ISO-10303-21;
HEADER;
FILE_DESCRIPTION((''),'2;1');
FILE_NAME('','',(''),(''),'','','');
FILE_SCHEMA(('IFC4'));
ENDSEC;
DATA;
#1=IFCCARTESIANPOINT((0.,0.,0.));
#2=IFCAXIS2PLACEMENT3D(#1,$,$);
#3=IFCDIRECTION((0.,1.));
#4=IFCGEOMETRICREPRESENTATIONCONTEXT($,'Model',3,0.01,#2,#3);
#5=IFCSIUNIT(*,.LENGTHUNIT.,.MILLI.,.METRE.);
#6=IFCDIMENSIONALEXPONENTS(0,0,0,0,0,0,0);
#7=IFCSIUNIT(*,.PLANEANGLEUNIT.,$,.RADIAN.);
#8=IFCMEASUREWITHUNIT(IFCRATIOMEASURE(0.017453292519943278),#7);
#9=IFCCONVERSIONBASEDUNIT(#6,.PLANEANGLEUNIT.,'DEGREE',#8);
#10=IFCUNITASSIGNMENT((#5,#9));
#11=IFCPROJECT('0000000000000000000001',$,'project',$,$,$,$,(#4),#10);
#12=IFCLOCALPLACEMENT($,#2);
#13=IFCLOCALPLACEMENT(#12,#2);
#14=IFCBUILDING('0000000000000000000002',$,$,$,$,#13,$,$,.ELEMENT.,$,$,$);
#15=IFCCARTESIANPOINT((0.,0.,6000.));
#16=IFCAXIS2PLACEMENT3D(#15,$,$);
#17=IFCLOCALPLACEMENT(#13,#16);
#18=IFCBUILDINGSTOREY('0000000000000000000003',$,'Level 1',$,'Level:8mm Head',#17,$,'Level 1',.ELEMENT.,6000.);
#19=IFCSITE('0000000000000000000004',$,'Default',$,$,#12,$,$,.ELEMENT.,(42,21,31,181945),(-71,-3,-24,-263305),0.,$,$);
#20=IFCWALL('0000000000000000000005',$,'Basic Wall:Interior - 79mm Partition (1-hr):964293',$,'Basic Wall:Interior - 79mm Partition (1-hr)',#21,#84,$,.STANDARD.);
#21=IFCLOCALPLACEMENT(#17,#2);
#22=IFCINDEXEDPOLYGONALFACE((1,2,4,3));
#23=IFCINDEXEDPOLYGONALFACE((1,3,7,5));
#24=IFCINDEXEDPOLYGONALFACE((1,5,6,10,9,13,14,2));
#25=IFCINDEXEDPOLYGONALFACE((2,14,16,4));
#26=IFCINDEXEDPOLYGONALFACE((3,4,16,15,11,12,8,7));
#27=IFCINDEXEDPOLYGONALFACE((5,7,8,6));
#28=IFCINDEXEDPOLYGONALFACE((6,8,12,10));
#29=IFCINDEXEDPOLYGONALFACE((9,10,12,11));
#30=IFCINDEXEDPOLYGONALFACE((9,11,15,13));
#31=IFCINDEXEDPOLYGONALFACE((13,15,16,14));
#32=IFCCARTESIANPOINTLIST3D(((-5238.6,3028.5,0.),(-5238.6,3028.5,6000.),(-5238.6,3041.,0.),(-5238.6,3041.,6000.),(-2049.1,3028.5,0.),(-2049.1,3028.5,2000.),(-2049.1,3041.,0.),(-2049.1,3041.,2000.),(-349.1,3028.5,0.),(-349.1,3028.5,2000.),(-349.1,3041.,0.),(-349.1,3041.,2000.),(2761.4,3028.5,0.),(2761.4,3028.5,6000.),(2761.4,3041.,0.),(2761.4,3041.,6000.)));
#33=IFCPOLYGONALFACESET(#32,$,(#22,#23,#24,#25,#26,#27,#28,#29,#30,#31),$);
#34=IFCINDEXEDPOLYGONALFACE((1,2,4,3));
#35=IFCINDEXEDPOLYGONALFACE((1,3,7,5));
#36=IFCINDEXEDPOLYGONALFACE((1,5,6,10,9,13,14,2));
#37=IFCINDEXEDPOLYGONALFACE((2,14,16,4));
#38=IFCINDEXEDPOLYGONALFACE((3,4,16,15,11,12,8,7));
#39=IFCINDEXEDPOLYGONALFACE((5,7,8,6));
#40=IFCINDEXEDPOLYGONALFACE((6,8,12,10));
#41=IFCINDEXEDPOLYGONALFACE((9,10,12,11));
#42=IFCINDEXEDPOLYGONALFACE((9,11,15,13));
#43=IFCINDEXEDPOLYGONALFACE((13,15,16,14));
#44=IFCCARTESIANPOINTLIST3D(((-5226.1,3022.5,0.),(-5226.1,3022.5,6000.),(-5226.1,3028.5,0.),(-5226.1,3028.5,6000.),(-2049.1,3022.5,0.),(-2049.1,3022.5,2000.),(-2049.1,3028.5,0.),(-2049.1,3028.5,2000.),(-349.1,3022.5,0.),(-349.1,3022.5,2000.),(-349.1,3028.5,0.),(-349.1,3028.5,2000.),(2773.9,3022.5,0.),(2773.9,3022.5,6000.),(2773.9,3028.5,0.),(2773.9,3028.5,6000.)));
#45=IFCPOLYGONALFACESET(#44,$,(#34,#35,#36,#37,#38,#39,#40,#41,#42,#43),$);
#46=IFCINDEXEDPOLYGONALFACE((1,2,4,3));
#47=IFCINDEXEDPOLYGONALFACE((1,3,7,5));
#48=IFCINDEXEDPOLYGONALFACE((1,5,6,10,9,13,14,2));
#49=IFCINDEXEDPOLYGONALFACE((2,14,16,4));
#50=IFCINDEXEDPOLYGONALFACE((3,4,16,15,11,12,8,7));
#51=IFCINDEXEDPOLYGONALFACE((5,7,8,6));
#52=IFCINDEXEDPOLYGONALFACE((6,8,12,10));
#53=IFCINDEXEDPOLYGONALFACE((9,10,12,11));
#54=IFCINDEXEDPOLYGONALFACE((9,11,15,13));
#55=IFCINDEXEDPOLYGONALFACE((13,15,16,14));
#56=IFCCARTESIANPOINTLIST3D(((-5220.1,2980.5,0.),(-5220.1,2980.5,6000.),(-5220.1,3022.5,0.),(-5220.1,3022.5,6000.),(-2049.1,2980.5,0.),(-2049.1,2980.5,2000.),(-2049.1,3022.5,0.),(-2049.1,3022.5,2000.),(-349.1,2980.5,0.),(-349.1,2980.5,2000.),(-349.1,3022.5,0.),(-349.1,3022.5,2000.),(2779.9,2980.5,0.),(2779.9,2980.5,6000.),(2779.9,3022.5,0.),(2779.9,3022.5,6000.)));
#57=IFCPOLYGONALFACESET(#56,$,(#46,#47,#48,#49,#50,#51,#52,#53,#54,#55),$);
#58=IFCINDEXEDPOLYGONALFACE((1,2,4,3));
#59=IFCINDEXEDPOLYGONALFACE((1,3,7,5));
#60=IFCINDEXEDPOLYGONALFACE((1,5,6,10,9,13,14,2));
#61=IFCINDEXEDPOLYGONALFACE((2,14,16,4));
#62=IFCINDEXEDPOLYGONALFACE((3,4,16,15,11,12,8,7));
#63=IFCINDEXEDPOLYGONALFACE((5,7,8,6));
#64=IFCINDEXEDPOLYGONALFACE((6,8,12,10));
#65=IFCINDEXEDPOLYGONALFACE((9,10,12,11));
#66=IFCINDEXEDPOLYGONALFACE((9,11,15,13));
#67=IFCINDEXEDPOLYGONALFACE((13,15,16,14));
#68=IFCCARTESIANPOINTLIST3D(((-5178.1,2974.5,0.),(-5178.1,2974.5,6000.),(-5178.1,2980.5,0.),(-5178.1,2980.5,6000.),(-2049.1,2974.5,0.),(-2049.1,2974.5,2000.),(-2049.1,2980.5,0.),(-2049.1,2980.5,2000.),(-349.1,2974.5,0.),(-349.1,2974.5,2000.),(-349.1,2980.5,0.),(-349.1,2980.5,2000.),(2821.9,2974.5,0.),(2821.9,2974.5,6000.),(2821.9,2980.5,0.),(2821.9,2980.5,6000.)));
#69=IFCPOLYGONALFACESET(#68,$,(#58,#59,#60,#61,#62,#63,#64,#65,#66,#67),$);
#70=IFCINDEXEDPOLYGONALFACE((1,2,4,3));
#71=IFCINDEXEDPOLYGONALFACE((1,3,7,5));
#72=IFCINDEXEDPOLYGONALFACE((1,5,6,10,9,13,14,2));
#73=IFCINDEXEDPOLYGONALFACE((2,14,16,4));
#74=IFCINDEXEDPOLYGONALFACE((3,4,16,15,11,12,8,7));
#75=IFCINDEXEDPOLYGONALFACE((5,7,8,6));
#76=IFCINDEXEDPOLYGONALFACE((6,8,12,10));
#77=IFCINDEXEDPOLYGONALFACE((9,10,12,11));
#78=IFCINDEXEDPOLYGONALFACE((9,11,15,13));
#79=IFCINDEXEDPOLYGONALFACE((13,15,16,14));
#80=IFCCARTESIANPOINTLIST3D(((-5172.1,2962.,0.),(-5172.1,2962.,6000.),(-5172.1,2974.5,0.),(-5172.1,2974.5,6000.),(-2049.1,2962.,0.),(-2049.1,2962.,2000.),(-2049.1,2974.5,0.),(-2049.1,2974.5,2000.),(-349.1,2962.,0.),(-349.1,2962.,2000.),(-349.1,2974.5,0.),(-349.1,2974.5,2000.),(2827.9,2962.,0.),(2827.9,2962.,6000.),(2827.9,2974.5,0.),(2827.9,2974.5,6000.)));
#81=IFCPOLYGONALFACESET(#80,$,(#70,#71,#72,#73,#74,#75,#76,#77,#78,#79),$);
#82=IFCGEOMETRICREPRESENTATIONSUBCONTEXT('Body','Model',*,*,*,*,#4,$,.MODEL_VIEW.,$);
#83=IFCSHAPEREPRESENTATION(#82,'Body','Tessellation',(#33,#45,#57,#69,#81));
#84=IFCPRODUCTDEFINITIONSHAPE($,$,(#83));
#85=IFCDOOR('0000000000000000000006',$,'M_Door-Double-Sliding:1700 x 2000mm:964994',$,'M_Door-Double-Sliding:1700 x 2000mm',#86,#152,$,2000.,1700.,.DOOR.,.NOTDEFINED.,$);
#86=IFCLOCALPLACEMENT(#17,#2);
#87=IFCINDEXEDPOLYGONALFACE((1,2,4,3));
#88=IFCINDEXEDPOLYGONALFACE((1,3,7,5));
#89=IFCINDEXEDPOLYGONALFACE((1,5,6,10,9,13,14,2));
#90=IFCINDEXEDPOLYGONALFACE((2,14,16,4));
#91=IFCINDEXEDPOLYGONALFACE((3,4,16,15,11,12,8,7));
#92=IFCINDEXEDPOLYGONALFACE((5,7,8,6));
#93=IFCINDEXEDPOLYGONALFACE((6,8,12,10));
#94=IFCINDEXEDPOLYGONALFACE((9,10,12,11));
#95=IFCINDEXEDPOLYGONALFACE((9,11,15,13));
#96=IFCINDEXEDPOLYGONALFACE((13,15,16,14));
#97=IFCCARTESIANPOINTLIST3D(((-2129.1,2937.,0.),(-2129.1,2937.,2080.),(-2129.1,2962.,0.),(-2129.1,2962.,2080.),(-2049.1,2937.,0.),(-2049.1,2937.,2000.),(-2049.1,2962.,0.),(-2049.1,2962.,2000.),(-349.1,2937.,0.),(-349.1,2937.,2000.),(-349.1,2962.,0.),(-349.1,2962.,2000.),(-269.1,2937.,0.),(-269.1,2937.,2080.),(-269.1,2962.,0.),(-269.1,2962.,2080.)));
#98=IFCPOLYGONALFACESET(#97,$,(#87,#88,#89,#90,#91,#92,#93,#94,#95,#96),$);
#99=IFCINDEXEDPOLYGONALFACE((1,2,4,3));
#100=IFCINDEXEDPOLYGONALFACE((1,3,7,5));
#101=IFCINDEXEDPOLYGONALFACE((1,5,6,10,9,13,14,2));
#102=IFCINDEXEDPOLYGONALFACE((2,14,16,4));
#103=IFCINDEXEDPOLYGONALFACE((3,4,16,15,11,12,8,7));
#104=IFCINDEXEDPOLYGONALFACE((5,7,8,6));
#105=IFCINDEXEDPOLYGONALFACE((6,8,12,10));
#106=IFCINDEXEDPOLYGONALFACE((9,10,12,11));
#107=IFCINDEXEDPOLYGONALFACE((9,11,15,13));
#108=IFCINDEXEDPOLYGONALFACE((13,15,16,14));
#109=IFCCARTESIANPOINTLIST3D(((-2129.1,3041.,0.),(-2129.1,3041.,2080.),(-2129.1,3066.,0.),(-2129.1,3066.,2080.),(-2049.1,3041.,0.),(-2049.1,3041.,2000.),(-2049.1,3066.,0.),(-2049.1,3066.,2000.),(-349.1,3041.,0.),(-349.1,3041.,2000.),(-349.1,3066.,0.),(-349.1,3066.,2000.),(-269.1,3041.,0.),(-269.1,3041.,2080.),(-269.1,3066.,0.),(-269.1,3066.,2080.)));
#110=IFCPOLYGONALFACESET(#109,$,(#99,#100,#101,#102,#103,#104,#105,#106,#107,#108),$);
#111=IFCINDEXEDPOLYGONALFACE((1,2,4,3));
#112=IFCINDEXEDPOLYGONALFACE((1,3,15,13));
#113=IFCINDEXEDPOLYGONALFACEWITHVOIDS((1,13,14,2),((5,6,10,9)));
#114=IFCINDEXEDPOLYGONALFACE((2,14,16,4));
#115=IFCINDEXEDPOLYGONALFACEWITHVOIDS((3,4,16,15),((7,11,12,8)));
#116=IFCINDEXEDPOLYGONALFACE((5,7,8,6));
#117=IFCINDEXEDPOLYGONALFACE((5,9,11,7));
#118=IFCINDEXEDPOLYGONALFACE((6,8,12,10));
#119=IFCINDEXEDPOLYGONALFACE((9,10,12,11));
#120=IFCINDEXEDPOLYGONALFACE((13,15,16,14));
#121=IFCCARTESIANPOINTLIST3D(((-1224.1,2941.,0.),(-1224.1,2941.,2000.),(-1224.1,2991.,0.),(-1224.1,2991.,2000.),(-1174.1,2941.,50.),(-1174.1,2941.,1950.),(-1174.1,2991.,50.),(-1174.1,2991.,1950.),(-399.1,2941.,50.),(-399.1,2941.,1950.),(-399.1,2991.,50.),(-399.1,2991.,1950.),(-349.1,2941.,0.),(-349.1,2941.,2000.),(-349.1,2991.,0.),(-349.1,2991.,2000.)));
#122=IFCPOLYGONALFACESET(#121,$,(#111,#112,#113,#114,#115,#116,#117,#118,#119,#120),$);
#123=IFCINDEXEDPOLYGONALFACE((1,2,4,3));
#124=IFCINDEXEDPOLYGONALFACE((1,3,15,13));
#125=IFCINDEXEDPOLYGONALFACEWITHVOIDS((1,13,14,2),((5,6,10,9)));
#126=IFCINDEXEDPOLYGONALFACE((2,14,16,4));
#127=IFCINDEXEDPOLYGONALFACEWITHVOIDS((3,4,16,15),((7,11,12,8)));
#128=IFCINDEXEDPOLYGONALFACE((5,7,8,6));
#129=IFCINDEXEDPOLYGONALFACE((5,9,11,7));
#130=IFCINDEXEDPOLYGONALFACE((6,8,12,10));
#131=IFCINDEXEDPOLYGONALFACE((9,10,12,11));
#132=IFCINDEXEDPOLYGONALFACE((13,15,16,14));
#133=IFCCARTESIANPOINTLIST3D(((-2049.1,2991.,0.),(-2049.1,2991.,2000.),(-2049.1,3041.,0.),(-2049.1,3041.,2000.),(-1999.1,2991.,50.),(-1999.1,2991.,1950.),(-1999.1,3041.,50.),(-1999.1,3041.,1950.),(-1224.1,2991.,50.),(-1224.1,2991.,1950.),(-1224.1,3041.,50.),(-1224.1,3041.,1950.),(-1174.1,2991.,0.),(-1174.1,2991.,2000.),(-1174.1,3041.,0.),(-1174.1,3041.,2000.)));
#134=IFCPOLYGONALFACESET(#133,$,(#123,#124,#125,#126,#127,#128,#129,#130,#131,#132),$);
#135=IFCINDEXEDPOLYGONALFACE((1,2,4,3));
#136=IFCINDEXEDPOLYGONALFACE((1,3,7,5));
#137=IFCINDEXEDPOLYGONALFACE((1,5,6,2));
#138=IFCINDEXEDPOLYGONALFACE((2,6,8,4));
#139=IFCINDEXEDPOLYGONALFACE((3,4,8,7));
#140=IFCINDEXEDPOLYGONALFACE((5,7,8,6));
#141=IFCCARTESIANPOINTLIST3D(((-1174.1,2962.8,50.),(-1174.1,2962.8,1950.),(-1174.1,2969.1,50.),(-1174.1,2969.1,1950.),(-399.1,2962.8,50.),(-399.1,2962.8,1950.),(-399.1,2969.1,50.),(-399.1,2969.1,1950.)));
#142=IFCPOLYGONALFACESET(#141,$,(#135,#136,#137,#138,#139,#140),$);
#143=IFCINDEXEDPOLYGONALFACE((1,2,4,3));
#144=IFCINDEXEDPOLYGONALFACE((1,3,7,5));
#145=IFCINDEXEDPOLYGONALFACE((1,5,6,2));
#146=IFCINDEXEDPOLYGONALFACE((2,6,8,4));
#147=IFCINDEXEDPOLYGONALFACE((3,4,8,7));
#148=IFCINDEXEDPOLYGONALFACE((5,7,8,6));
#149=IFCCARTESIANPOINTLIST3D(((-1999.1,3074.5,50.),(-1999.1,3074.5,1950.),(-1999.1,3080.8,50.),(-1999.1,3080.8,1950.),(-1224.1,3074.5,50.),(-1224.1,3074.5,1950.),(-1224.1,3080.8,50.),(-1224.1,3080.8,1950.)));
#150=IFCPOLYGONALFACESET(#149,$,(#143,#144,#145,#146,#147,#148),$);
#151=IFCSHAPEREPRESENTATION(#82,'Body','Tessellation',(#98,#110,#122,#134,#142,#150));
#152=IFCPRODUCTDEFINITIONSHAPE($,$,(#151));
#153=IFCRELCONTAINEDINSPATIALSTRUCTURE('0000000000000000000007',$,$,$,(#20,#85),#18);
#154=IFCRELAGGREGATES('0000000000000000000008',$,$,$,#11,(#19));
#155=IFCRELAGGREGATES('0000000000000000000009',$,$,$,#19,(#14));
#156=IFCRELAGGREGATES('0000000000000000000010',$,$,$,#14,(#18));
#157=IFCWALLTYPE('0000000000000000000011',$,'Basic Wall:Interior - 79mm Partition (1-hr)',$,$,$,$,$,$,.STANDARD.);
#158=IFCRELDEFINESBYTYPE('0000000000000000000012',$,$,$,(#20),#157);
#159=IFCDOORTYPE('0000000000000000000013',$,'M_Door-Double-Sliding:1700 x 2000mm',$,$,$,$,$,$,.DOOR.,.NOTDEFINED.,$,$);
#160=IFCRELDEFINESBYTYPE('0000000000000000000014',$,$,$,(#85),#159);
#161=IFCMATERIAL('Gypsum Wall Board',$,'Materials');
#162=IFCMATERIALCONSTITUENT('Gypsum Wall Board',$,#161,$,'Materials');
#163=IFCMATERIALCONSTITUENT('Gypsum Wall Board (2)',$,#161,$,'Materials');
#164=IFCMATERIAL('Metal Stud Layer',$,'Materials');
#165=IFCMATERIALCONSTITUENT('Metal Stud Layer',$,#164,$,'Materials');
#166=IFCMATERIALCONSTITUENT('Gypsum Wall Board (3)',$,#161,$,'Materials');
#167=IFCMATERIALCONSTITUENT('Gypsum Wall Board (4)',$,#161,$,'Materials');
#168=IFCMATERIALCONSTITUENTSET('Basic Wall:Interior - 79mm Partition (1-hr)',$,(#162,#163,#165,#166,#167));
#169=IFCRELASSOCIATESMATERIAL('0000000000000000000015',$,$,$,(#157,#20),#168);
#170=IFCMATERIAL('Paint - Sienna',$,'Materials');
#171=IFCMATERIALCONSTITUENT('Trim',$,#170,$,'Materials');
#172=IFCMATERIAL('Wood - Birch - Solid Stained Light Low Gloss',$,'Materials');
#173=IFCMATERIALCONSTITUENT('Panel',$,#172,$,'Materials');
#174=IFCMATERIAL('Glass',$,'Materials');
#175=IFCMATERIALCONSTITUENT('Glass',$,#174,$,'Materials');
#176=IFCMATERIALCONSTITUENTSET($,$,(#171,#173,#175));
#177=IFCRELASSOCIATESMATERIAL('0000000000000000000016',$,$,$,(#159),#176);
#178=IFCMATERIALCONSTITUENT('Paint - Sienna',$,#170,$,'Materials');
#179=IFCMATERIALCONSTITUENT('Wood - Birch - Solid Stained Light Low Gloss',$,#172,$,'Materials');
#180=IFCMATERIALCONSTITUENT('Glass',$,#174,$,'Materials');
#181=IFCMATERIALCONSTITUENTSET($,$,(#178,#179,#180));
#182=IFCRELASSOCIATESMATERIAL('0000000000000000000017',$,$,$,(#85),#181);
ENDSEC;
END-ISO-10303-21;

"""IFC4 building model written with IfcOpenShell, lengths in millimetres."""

from ifc_helpers import new_model, entity, si_unit, converted_unit, direction, frame, origin, place, context, subcontext, project, spatial, indexed_curve, outline, extrude, source, transform, mapped, material, constituent, constituent_set, type_object, type_shapes, element, fill, save


model = new_model("IFC4")

# Units and contexts
model_context = context("Model", 3, precision=0.01, world=origin(), true_north=direction((0.0, 1.0)))
body_context = subcontext(model_context, "Body", "Model", "MODEL_VIEW")
ifc_project = project(units=[si_unit("LENGTHUNIT", "METRE", prefix="MILLI"), converted_unit("PLANEANGLEUNIT", "DEGREE", entity("IfcRatioMeasure", 0.017453292519943278), si_unit("PLANEANGLEUNIT", "RADIAN"), dimensions=[0, 0, 0, 0, 0, 0, 0])], contexts=[model_context])

# Site, building, storey
site_placement = place(None, origin())
site = spatial("IfcSite", under=ifc_project, at=site_placement, Name="Default", CompositionType="ELEMENT", RefLatitude=(42, 21, 31, 181945), RefLongitude=(-71, -3, -24, -263305), RefElevation=0.0)
building_placement = place(site_placement, origin())
building = spatial("IfcBuilding", under=site, at=building_placement, CompositionType="ELEMENT")
storey_placement = place(building_placement, frame((0.0, 0.0, 6000.0)))
storey = spatial("IfcBuildingStorey", under=building, at=storey_placement, Name="Level 1", ObjectType="Level:8mm Head", LongName="Level 1", CompositionType="ELEMENT", Elevation=6000.0)

# Shared definitions
ifc_material_1 = material(Name="Gypsum Wall Board", Category="Materials")
ifc_constituent_1 = constituent(ifc_material_1, Name="Gypsum Wall Board", Category="Materials")
ifc_constituent_2 = constituent(ifc_material_1, Name="Gypsum Wall Board (2)", Category="Materials")
ifc_material_2 = material(Name="Metal Stud Layer", Category="Materials")
ifc_constituent_3 = constituent(ifc_material_2, Name="Metal Stud Layer", Category="Materials")
ifc_constituent_4 = constituent(ifc_material_1, Name="Gypsum Wall Board (3)", Category="Materials")
ifc_constituent_5 = constituent(ifc_material_1, Name="Gypsum Wall Board (4)", Category="Materials")
ifc_constituent_set_1 = constituent_set(constituents=[ifc_constituent_1, ifc_constituent_2, ifc_constituent_3, ifc_constituent_4, ifc_constituent_5], Name="Basic Wall:Interior - 79mm Partition (1-hr)")
wall_type = type_object("IfcWallType", Name="Basic Wall:Interior - 79mm Partition (1-hr)", PredefinedType="STANDARD", material=ifc_constituent_set_1)

# Wall, opening, door
wall_1_placement = place(storey_placement, frame((2761.4, 3001.5, 0.0), z_axis=(0.0, 0.0, 1.0), x_axis=(-1.0, 0.0, 0.0)))
wall_1 = element("IfcWall", 1, at=wall_1_placement, inside=storey, type_object=wall_type, material=ifc_constituent_set_1, Name="Basic Wall:Interior - 79mm Partition (1-hr):964293", ObjectType="Basic Wall:Interior - 79mm Partition (1-hr)", PredefinedType="STANDARD", context=body_context, shape_type="SweptSolid", body=[
    extrude(outline(indexed_curve([(-2000.0, -869.8), (-2000.0, -3980.3), (4000.0, -3980.3), (4000.0, 4019.8), (-2000.0, 4019.8), (-2000.0, 830.2), (0.0, 830.2), (0.0, -869.8), (-2000.0, -869.8)], self_intersect=False)), frame((3980.3, -27.0, 2000.0), z_axis=(0.0, 1.0, 0.0), x_axis=(0.0, 0.0, 1.0)), (0.0, 0.0, -1.0), 12.5),
    extrude(outline(indexed_curve([(-2000.0, -863.5), (-2000.0, -3986.5), (4000.0, -3986.5), (4000.0, 4013.5), (-2000.0, 4013.5), (-2000.0, 836.5), (0.0, 836.5), (0.0, -863.5), (-2000.0, -863.5)], self_intersect=False)), frame((3974.0, -21.0, 2000.0), z_axis=(0.0, 1.0, 0.0), x_axis=(0.0, 0.0, 1.0)), (0.0, 0.0, -1.0), 6.0),
    extrude(outline(indexed_curve([(-2000.0, -860.5), (-2000.0, -3989.5), (4000.0, -3989.5), (4000.0, 4010.5), (-2000.0, 4010.5), (-2000.0, 839.5), (0.0, 839.5), (0.0, -860.5), (-2000.0, -860.5)], self_intersect=False)), frame((3971.0, 21.0, 2000.0), z_axis=(0.0, 1.0, 0.0), x_axis=(0.0, 0.0, 1.0)), (0.0, 0.0, -1.0), 42.0),
    extrude(outline(indexed_curve([(-2000.0, -839.5), (-2000.0, -4010.5), (4000.0, -4010.5), (4000.0, 3989.5), (-2000.0, 3989.5), (-2000.0, 860.5), (0.0, 860.5), (0.0, -839.5), (-2000.0, -839.5)], self_intersect=False)), frame((3950.0, 27.0, 2000.0), z_axis=(0.0, 1.0, 0.0), x_axis=(0.0, 0.0, 1.0)), (0.0, 0.0, -1.0), 6.0),
    extrude(outline(indexed_curve([(-1631.3, 200.0), (-1631.3, 2200.0), (-4808.3, 2200.0), (-4808.3, -3800.0), (3179.2, -3800.0), (3191.7, -3800.0), (3191.7, 2200.0), (3179.2, 2200.0), (68.7, 2200.0), (68.7, 200.0), (-1631.3, 200.0)], self_intersect=False)), frame((4741.8, 39.5, 2200.0), z_axis=(0.0, 1.0, 0.0), x_axis=(1.0, 0.0, 0.0)), (0.0, 0.0, -1.0), 12.5),
])
opening_1_placement = place(wall_1_placement, frame((4810.5, 39.5, 0.0)))
opening_1 = element("IfcOpeningElement", 2, at=opening_1_placement, cuts=wall_1, PredefinedType="OPENING", context=body_context, shape_type="SweptSolid", body=[
    extrude(outline(indexed_curve([(2000.0, 0.0), (2000.0, 1700.0), (0.0, 1700.0), (0.0, 0.0), (2000.0, 0.0)], self_intersect=False)), frame((0.0, 0.0, 0.0), z_axis=(0.0, -1.0, 0.0), x_axis=(0.0, 0.0, 1.0)), (0.0, 0.0, 1.0), 79.0),
])
ifc_material_3 = material(Name="Paint - Sienna", Category="Materials")
ifc_constituent_6 = constituent(ifc_material_3, Name="Paint - Sienna", Category="Materials")
ifc_material_4 = material(Name="Wood - Birch - Solid Stained Light Low Gloss", Category="Materials")
ifc_constituent_7 = constituent(ifc_material_4, Name="Wood - Birch - Solid Stained Light Low Gloss", Category="Materials")
ifc_material_5 = material(Name="Glass", Category="Materials")
ifc_constituent_8 = constituent(ifc_material_5, Name="Glass", Category="Materials")
ifc_constituent_set_2 = constituent_set(constituents=[ifc_constituent_6, ifc_constituent_7, ifc_constituent_8])
ifc_constituent_9 = constituent(ifc_material_3, Name="Trim", Category="Materials")
ifc_constituent_10 = constituent(ifc_material_4, Name="Panel", Category="Materials")
ifc_constituent_11 = constituent(ifc_material_5, Name="Glass", Category="Materials")
ifc_constituent_set_3 = constituent_set(constituents=[ifc_constituent_9, ifc_constituent_10, ifc_constituent_11])
door_type = type_object("IfcDoorType", Name="M_Door-Double-Sliding:1700 x 2000mm", OperationType="NOTDEFINED", PredefinedType="DOOR", material=ifc_constituent_set_3)
shared_shape_1 = source(origin(), body_context, "Body", "SweptSolid", [
    extrude(outline(indexed_curve([(-1020.0, -930.0), (1060.0, -930.0), (1060.0, 930.0), (-1020.0, 930.0), (-1020.0, 850.0), (980.0, 850.0), (980.0, -850.0), (-1020.0, -850.0), (-1020.0, -930.0)], self_intersect=False)), frame((850.0, -25.0, 1020.0), z_axis=(0.0, 1.0, 0.0), x_axis=(0.0, 0.0, 1.0)), (0.0, 0.0, 1.0), 25.0),
    extrude(outline(indexed_curve([(-930.0, -1020.0), (-850.0, -1020.0), (-850.0, 980.0), (850.0, 980.0), (850.0, -1020.0), (930.0, -1020.0), (930.0, 1060.0), (-930.0, 1060.0), (-930.0, -1020.0)], self_intersect=False)), frame((850.0, 79.0, 1020.0), z_axis=(0.0, 1.0, 0.0), x_axis=(-1.0, 0.0, 0.0)), (0.0, 0.0, 1.0), 25.0),
    extrude(outline(indexed_curve([(-437.5, -1000.0), (437.5, -1000.0), (437.5, 1000.0), (-437.5, 1000.0), (-437.5, -1000.0)], self_intersect=False), holes=[indexed_curve([(-387.5, -950.0), (-387.5, 950.0), (387.5, 950.0), (387.5, -950.0), (-387.5, -950.0)], self_intersect=False)]), frame((1262.5, -21.0, 1000.0), z_axis=(0.0, 1.0, 0.0), x_axis=(1.0, 0.0, 0.0)), (0.0, 0.0, 1.0), 50.0),
    extrude(outline(indexed_curve([(-1000.0, -437.5), (1000.0, -437.5), (1000.0, 437.5), (-1000.0, 437.5), (-1000.0, -437.5)], self_intersect=False), holes=[indexed_curve([(-950.0, -387.5), (-950.0, 387.5), (950.0, 387.5), (950.0, -387.5), (-950.0, -387.5)], self_intersect=False)]), frame((437.5, 29.0, 1000.0), z_axis=(0.0, 1.0, 0.0), x_axis=(0.0, 0.0, -1.0)), (0.0, 0.0, 1.0), 50.0),
    extrude(outline(indexed_curve([(-3.2, -387.5), (3.2, -387.5), (3.2, 387.5), (-3.2, 387.5), (-3.2, -387.5)], self_intersect=False)), frame((1262.5, 4.0, 50.0), z_axis=(0.0, 0.0, 1.0), x_axis=(0.0, -1.0, 0.0)), (0.0, 0.0, 1.0), 1900.0),
    extrude(outline(indexed_curve([(-3.2, -387.5), (3.2, -387.5), (3.2, 387.5), (-3.2, 387.5), (-3.2, -387.5)], self_intersect=False)), frame((437.5, 115.7, 50.0), z_axis=(0.0, 0.0, 1.0), x_axis=(0.0, 1.0, 0.0)), (0.0, 0.0, 1.0), 1900.0),
])
type_shapes(door_type, [shared_shape_1])
door_1_placement = place(opening_1_placement, frame((0.0, 0.0, 0.0), z_axis=(0.0, 0.0, 1.0), x_axis=(-1.0, 0.0, 0.0)))
door_1 = element("IfcDoor", 3, at=door_1_placement, inside=storey, type_object=door_type, material=ifc_constituent_set_2, Name="M_Door-Double-Sliding:1700 x 2000mm:964994", ObjectType="M_Door-Double-Sliding:1700 x 2000mm", OperationType="NOTDEFINED", OverallHeight=2000.0, OverallWidth=1700.0, PredefinedType="DOOR", context=body_context, shape_type="MappedRepresentation", body=[
    mapped(shared_shape_1, transform((0.0, 0.0, 0.0), scale=1.0)),
])
fill(opening_1, door_1)

save(model, "model.ifc")
